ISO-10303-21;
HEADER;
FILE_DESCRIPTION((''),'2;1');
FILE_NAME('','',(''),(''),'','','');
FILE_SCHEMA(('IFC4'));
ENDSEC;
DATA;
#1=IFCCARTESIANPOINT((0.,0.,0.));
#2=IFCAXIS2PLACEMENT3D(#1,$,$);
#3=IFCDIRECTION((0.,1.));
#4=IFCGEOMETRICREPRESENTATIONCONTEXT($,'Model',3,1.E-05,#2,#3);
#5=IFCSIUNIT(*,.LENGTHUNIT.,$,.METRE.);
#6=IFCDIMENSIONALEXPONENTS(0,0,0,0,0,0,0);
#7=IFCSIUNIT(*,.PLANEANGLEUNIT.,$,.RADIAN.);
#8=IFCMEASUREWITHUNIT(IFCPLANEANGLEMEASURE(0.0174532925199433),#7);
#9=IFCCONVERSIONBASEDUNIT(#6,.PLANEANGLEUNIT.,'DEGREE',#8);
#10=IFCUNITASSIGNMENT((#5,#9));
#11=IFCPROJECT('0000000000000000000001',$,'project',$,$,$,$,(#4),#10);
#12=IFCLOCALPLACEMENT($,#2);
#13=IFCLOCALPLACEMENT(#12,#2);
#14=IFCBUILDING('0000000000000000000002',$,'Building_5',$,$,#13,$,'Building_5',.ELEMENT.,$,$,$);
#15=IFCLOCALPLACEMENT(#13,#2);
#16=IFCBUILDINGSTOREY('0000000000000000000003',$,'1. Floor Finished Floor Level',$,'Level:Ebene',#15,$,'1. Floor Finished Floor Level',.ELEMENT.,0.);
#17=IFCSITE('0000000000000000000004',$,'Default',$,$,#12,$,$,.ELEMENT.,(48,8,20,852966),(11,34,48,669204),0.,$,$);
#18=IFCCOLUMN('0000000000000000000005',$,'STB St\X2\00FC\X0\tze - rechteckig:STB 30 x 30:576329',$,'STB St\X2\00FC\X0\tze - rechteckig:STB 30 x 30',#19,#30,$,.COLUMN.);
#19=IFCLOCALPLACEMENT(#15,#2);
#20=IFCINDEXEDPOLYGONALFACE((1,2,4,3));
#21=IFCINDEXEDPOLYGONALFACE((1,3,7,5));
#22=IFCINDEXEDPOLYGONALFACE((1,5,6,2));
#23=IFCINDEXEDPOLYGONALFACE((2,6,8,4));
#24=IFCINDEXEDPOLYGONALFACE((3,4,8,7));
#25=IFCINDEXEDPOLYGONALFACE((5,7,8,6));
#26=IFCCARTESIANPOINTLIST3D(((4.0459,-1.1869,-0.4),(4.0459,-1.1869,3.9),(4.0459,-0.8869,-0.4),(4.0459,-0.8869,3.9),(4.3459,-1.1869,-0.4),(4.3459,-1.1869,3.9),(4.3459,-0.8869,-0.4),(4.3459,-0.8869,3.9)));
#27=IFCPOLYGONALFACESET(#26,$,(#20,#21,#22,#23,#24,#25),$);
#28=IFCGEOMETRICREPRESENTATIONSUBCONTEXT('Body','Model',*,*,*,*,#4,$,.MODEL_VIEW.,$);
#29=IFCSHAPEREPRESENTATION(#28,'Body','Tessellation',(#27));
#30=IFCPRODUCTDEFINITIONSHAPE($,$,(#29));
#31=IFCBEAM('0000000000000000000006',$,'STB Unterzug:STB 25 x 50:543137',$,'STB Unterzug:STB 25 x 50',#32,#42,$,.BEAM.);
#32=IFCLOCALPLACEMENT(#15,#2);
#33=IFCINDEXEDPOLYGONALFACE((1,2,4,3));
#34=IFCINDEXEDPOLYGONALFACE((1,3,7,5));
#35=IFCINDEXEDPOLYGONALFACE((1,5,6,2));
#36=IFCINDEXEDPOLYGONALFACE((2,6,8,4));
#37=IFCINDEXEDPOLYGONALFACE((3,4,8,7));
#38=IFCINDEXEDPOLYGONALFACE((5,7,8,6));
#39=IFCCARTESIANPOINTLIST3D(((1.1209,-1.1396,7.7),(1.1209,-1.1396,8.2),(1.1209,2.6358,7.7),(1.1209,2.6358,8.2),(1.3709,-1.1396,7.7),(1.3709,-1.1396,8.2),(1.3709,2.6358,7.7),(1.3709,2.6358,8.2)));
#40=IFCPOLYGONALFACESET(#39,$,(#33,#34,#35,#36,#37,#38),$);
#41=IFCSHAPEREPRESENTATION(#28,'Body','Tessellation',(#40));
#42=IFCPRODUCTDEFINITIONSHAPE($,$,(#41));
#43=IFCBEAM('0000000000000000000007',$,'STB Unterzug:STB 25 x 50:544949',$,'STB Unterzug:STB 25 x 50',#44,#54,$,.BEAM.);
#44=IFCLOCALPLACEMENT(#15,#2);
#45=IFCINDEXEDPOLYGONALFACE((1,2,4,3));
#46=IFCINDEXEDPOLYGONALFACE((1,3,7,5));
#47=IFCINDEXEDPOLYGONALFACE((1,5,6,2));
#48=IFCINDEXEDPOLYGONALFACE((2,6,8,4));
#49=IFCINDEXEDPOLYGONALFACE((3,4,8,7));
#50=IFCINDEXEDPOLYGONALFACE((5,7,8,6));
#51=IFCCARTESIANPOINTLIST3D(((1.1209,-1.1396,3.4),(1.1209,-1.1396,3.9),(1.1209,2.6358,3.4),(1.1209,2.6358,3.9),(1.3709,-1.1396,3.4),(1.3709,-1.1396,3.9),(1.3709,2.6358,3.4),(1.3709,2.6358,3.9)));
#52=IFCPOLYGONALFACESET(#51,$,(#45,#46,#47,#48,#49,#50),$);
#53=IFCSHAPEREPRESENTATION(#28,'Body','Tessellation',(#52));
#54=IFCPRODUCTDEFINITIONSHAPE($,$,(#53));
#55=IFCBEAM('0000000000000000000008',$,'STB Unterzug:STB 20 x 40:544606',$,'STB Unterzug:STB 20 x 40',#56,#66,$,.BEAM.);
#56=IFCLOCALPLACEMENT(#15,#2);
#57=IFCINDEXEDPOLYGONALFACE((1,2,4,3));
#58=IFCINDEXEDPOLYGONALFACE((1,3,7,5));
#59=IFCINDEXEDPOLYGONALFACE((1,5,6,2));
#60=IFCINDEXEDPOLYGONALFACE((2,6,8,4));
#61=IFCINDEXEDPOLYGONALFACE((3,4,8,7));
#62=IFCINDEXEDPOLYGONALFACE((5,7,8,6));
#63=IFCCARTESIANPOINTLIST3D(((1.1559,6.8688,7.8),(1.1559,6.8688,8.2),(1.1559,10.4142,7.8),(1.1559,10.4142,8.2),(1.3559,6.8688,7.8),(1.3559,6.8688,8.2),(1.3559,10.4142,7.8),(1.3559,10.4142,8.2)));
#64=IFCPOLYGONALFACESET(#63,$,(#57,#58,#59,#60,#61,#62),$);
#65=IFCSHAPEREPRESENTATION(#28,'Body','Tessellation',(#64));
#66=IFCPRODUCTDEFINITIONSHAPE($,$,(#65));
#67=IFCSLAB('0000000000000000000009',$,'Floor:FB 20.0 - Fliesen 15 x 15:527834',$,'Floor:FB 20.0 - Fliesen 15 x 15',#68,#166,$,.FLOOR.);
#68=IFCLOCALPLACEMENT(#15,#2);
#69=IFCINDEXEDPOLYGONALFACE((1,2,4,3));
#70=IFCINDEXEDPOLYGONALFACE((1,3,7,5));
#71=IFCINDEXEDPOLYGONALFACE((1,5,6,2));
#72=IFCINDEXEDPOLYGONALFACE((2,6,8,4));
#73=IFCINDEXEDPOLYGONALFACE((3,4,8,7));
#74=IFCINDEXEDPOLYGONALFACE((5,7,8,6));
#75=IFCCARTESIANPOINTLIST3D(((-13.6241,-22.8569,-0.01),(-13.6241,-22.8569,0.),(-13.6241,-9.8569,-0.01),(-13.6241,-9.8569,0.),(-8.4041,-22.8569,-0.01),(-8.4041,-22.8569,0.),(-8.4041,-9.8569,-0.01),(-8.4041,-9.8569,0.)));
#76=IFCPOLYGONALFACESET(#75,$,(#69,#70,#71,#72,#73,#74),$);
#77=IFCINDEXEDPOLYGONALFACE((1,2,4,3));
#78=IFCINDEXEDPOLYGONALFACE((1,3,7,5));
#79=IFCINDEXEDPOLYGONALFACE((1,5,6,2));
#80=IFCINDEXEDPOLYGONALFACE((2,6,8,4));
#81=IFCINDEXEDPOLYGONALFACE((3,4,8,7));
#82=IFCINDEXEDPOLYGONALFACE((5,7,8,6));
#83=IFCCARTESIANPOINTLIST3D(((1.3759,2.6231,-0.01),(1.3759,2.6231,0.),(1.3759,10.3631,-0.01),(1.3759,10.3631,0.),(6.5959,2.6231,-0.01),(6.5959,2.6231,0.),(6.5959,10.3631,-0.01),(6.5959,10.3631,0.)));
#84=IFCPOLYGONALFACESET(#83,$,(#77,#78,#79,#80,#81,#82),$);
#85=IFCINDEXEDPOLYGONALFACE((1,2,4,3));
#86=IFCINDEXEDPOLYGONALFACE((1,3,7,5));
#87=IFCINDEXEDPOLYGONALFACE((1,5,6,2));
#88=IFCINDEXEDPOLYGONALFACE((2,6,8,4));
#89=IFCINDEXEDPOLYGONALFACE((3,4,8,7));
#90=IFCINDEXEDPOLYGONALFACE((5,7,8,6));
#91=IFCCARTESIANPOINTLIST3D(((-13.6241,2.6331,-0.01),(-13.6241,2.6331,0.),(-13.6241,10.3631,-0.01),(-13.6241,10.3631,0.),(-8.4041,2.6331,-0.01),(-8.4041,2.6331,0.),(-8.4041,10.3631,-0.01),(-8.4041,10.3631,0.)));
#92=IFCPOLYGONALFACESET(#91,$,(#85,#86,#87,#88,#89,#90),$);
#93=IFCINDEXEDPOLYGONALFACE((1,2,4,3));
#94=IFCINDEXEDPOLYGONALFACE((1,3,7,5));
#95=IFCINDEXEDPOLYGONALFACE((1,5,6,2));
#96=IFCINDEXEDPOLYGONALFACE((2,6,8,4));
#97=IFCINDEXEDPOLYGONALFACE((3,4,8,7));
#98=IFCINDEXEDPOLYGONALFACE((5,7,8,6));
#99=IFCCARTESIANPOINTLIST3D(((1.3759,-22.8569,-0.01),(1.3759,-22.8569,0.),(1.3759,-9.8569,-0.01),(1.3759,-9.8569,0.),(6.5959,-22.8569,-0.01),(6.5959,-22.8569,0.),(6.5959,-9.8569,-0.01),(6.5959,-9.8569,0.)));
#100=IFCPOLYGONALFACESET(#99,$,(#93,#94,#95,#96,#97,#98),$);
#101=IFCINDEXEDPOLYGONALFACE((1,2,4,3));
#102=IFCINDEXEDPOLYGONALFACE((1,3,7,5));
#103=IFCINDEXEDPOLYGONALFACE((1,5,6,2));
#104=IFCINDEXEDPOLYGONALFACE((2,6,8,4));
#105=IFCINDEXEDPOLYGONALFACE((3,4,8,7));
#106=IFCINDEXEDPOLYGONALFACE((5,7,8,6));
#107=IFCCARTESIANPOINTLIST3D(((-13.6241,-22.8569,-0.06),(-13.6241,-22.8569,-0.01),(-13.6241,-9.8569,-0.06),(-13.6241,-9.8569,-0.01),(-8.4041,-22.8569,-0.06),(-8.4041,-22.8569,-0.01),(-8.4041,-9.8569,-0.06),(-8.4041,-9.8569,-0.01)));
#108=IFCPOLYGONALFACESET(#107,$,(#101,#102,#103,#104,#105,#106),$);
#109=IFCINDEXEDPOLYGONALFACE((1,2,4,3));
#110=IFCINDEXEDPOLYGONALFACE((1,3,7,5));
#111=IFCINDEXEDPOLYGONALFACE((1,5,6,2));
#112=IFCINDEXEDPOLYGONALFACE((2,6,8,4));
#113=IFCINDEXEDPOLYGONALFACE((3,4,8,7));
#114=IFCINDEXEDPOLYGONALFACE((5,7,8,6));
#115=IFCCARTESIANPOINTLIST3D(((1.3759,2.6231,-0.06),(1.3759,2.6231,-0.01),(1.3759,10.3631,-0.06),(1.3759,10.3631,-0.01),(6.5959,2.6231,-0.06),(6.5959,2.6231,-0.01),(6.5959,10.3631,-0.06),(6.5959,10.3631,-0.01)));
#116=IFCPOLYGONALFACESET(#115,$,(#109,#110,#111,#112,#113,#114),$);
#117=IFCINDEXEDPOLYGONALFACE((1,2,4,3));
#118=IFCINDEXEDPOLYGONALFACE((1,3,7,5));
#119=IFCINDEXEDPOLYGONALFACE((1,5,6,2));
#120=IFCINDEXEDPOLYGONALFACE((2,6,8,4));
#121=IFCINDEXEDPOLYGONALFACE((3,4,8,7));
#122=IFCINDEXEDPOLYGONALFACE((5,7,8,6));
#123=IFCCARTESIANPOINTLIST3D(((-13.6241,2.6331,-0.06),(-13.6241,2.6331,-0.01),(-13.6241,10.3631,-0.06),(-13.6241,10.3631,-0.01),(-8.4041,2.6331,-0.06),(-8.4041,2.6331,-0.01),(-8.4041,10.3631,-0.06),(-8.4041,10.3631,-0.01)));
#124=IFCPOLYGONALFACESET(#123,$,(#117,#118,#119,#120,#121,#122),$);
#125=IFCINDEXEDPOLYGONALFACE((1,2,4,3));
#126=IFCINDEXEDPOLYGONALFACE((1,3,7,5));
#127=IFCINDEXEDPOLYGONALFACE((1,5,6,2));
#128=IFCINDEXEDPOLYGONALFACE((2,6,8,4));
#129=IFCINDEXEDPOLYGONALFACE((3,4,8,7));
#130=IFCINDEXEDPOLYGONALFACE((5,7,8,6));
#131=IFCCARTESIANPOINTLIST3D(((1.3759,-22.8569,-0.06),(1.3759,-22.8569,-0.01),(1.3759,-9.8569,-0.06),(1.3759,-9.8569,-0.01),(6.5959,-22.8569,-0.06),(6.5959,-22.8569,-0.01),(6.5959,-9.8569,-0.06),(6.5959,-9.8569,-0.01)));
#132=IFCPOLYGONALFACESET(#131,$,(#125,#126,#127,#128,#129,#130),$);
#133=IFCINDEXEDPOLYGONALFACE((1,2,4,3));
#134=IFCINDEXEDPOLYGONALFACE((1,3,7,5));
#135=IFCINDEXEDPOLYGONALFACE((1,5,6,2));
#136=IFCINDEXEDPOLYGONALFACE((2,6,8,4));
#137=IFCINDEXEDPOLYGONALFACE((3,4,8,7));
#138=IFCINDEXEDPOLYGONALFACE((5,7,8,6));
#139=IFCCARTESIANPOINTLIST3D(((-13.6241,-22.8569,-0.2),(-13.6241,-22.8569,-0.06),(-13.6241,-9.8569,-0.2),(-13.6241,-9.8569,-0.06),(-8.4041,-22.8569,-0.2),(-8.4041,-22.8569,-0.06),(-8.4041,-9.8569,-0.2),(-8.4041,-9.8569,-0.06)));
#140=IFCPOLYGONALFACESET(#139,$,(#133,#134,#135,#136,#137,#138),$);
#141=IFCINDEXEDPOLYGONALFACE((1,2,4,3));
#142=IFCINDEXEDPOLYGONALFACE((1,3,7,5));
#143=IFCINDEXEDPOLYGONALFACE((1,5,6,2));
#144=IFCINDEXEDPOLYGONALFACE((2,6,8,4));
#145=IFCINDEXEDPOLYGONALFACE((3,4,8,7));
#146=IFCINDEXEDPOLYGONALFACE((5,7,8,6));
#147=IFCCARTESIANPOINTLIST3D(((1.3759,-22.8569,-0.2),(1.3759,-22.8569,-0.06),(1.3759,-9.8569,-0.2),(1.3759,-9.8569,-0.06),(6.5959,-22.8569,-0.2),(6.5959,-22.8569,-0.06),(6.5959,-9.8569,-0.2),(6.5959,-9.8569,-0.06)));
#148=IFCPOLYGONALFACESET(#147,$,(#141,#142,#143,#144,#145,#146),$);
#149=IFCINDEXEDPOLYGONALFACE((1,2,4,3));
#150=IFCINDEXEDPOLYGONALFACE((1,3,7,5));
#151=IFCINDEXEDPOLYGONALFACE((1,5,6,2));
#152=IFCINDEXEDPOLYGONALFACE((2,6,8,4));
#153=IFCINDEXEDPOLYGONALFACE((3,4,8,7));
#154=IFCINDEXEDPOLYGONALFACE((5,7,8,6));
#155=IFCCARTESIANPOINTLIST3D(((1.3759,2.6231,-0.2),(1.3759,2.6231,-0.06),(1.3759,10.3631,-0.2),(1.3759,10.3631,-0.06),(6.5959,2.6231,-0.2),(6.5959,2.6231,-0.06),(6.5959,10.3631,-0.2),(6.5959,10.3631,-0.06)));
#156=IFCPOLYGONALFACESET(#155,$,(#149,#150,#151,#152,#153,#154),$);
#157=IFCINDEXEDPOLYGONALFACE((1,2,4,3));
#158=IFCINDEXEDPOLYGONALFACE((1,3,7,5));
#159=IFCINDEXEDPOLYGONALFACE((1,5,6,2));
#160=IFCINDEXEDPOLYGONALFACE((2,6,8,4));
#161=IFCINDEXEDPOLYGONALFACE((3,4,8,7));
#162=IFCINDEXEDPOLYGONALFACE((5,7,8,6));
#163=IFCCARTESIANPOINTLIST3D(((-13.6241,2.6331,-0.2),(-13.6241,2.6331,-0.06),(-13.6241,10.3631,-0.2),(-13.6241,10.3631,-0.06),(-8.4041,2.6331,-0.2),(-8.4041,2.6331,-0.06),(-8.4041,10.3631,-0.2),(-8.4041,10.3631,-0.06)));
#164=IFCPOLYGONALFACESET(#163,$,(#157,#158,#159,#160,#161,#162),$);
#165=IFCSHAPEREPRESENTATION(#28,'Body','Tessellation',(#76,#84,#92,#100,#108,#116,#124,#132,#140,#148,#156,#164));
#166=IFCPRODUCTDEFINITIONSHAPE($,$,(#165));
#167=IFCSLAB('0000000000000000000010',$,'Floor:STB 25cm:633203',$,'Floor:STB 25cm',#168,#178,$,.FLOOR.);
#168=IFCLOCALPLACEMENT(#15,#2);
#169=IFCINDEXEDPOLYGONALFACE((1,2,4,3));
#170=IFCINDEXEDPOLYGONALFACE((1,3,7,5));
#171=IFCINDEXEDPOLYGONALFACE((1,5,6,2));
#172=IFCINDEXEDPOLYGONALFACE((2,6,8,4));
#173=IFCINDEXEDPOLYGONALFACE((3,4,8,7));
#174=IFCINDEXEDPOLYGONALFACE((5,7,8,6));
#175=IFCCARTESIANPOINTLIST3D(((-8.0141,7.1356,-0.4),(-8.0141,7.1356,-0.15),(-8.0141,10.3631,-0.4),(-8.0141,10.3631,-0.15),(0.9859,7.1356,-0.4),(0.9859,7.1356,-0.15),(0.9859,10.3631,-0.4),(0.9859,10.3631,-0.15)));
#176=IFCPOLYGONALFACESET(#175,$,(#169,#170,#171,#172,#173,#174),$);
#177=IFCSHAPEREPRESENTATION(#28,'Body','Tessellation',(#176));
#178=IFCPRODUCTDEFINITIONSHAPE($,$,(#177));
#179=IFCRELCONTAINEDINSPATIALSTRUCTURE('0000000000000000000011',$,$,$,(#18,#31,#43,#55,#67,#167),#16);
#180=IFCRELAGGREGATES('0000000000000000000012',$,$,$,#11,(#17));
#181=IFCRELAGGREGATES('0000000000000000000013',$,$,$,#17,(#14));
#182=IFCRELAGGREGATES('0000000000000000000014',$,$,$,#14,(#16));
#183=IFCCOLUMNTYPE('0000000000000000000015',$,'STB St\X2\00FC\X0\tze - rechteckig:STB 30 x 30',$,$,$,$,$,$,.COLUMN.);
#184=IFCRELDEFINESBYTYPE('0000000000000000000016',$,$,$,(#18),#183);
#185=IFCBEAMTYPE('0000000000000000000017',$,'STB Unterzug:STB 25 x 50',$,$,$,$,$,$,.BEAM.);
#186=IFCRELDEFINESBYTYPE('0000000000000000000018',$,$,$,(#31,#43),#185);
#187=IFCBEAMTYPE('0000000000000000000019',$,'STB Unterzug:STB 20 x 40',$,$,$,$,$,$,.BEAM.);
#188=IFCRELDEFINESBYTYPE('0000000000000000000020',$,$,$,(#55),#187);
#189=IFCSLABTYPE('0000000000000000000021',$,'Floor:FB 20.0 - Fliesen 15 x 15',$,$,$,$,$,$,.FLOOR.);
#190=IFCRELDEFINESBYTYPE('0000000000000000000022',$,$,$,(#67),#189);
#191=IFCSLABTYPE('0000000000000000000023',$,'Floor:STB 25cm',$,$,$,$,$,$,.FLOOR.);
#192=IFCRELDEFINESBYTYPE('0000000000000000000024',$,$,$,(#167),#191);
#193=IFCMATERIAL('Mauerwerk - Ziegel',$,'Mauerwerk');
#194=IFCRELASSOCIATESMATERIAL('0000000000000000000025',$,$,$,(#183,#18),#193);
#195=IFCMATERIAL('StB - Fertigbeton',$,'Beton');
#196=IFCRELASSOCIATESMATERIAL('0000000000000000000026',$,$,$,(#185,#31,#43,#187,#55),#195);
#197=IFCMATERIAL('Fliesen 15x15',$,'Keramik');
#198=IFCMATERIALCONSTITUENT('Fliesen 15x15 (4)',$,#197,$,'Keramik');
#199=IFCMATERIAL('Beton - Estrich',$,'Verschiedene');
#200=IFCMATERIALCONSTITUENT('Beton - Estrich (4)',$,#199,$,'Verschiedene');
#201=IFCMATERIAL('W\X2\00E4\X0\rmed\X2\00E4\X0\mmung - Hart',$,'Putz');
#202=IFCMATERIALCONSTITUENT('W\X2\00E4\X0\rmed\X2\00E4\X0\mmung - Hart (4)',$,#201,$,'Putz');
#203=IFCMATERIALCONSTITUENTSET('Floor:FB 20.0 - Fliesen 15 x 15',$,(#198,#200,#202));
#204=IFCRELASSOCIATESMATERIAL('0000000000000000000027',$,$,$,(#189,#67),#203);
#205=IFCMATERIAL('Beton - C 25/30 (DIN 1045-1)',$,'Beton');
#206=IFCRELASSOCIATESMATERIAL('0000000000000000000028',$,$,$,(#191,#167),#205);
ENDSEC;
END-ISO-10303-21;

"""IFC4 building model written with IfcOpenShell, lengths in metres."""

from ifc_helpers import new_model, entity, si_unit, converted_unit, direction, frame, origin, place, context, subcontext, project, spatial, indexed_curve, outline, extrude, source, transform, mapped, material, constituent, constituent_set, type_object, type_shapes, element, save


model = new_model("IFC4")

# Units and contexts
model_context = context("Model", 3, precision=1e-05, world=origin(), true_north=direction((0.0, 1.0)))
body_context = subcontext(model_context, "Body", "Model", "MODEL_VIEW")
ifc_project = project(units=[si_unit("LENGTHUNIT", "METRE"), converted_unit("PLANEANGLEUNIT", "DEGREE", entity("IfcPlaneAngleMeasure", 0.0174532925199433), si_unit("PLANEANGLEUNIT", "RADIAN"), dimensions=[0, 0, 0, 0, 0, 0, 0])], contexts=[model_context])

# Site, building, storey
site_placement = place(None, origin())
site = spatial("IfcSite", under=ifc_project, at=site_placement, Name="Default", CompositionType="ELEMENT", RefLatitude=(48, 8, 20, 852966), RefLongitude=(11, 34, 48, 669204), RefElevation=0.0)
building_placement = place(site_placement, origin())
building = spatial("IfcBuilding", under=site, at=building_placement, Name="Building_5", LongName="Building_5", CompositionType="ELEMENT")
storey_placement = place(building_placement, origin())
storey = spatial("IfcBuildingStorey", under=building, at=storey_placement, Name="1. Floor Finished Floor Level", ObjectType="Level:Ebene", LongName="1. Floor Finished Floor Level", CompositionType="ELEMENT", Elevation=0.0)

# Column
ifc_material_1 = material(Name="Mauerwerk - Ziegel", Category="Mauerwerk")
column_type = type_object("IfcColumnType", Name="STB Stütze - rechteckig:STB 30 x 30", PredefinedType="COLUMN", material=ifc_material_1)
shared_shape_1 = source(origin(), body_context, "Body", "SweptSolid", [
    extrude(outline(indexed_curve([(-0.15, -0.15), (0.15, -0.15), (0.15, 0.15), (-0.15, 0.15), (-0.15, -0.15)], self_intersect=False)), frame((0.0, 0.0, -0.4), z_axis=(0.0, 0.0, 1.0), x_axis=(-1.0, 0.0, 0.0)), (0.0, 0.0, 1.0), 4.3),
])
type_shapes(column_type, [shared_shape_1])
column_placement = place(storey_placement, frame((4.1959, -1.0369, 0.0)))
element("IfcColumn", 1, at=column_placement, inside=storey, type_object=column_type, material=ifc_material_1, Name="STB Stütze - rechteckig:STB 30 x 30:576329", ObjectType="STB Stütze - rechteckig:STB 30 x 30", PredefinedType="COLUMN", context=body_context, shape_type="MappedRepresentation", body=[
    mapped(shared_shape_1, transform((0.0, 0.0, 0.0), scale=1.0)),
])

# Beams
ifc_material_2 = material(Name="StB - Fertigbeton", Category="Beton")
beam_type_1 = type_object("IfcBeamType", Name="STB Unterzug:STB 25 x 50", PredefinedType="BEAM", material=ifc_material_2)
shared_shape_2 = source(origin(), body_context, "Body", "SweptSolid", [
    extrude(outline(indexed_curve([(-1.8877, -0.125), (1.8877, -0.125), (1.8877, 0.125), (-1.8877, 0.125), (-1.8877, -0.125)], self_intersect=False)), frame((0.0, 0.0, -0.25), z_axis=(0.0, 0.0, 1.0), x_axis=(-1.0, 0.0, 0.0)), (0.0, 0.0, 1.0), 0.5),
])
type_shapes(beam_type_1, [shared_shape_2])
for number, where, z_axis, x_axis, name in (
    (2, (1.2459, 0.7481, 7.95), (0.0, 0.0, 1.0), (0.0, 1.0, 0.0), "STB Unterzug:STB 25 x 50:543137"),
    (3, (1.2459, 0.7481, 3.65), (0.0, 0.0, 1.0), (0.0, 1.0, 0.0), "STB Unterzug:STB 25 x 50:544949"),
):
    element("IfcBeam", number, at=place(storey_placement, frame(where, z_axis=z_axis, x_axis=x_axis)), inside=storey, type_object=beam_type_1, material=ifc_material_2, Name=name, ObjectType="STB Unterzug:STB 25 x 50", PredefinedType="BEAM", context=body_context, shape_type="MappedRepresentation", body=[
        mapped(shared_shape_2, transform((0.0, 0.0, 0.0), scale=1.0)),
    ])
beam_type_2 = type_object("IfcBeamType", Name="STB Unterzug:STB 20 x 40", PredefinedType="BEAM", material=ifc_material_2)
shared_shape_3 = source(origin(), body_context, "Body", "SweptSolid", [
    extrude(outline(indexed_curve([(-1.7727, -0.1), (1.7727, -0.1), (1.7727, 0.1), (-1.7727, 0.1), (-1.7727, -0.1)], self_intersect=False)), frame((0.0, 0.0, -0.2), z_axis=(0.0, 0.0, 1.0), x_axis=(-1.0, 0.0, 0.0)), (0.0, 0.0, 1.0), 0.4),
])
type_shapes(beam_type_2, [shared_shape_3])
beam_placement = place(storey_placement, frame((1.2559, 8.6415, 8.0), z_axis=(0.0, 0.0, 1.0), x_axis=(0.0, 1.0, 0.0)))
element("IfcBeam", 4, at=beam_placement, inside=storey, type_object=beam_type_2, material=ifc_material_2, Name="STB Unterzug:STB 20 x 40:544606", ObjectType="STB Unterzug:STB 20 x 40", PredefinedType="BEAM", context=body_context, shape_type="MappedRepresentation", body=[
    mapped(shared_shape_3, transform((0.0, 0.0, 0.0), scale=1.0)),
])

# Slabs
ifc_material_3 = material(Name="Fliesen 15x15", Category="Keramik")
ifc_constituent_1 = constituent(ifc_material_3, Name="Fliesen 15x15 (4)", Category="Keramik")
ifc_material_4 = material(Name="Beton - Estrich", Category="Verschiedene")
ifc_constituent_2 = constituent(ifc_material_4, Name="Beton - Estrich (4)", Category="Verschiedene")
ifc_material_5 = material(Name="Wärmedämmung - Hart", Category="Putz")
ifc_constituent_3 = constituent(ifc_material_5, Name="Wärmedämmung - Hart (4)", Category="Putz")
ifc_constituent_set_1 = constituent_set(constituents=[ifc_constituent_1, ifc_constituent_2, ifc_constituent_3], Name="Floor:FB 20.0 - Fliesen 15 x 15")
slab_type_1 = type_object("IfcSlabType", Name="Floor:FB 20.0 - Fliesen 15 x 15", PredefinedType="FLOOR", material=ifc_constituent_set_1)
slab_1_placement = place(storey_placement, origin())
element("IfcSlab", 5, at=slab_1_placement, inside=storey, type_object=slab_type_1, material=ifc_constituent_set_1, Name="Floor:FB 20.0 - Fliesen 15 x 15:527834", ObjectType="Floor:FB 20.0 - Fliesen 15 x 15", PredefinedType="FLOOR", context=body_context, shape_type="SweptSolid", body=[
    extrude(outline(indexed_curve([(-2.61, -6.5), (2.61, -6.5), (2.61, 6.5), (-2.61, 6.5), (-2.61, -6.5)], self_intersect=False)), frame((-11.0141, -16.3569, -0.01), z_axis=(0.0, 0.0, 1.0), x_axis=(-1.0, 0.0, 0.0)), (0.0, 0.0, 1.0), 0.01),
    extrude(outline(indexed_curve([(-2.61, -3.87), (2.61, -3.87), (2.61, 3.87), (-2.61, 3.87), (-2.61, -3.87)], self_intersect=False)), frame((3.9859, 6.4931, -0.01), z_axis=(0.0, 0.0, 1.0), x_axis=(-1.0, 0.0, 0.0)), (0.0, 0.0, 1.0), 0.01),
    extrude(outline(indexed_curve([(-2.61, -3.865), (2.61, -3.865), (2.61, 3.865), (-2.61, 3.865), (-2.61, -3.865)], self_intersect=False)), frame((-11.0141, 6.4981, -0.01), z_axis=(0.0, 0.0, 1.0), x_axis=(-1.0, 0.0, 0.0)), (0.0, 0.0, 1.0), 0.01),
    extrude(outline(indexed_curve([(-2.61, -6.5), (2.61, -6.5), (2.61, 6.5), (-2.61, 6.5), (-2.61, -6.5)], self_intersect=False)), frame((3.9859, -16.3569, -0.01), z_axis=(0.0, 0.0, 1.0), x_axis=(-1.0, 0.0, 0.0)), (0.0, 0.0, 1.0), 0.01),
    extrude(outline(indexed_curve([(-2.61, -6.5), (2.61, -6.5), (2.61, 6.5), (-2.61, 6.5), (-2.61, -6.5)], self_intersect=False)), frame((-11.0141, -16.3569, -0.06), z_axis=(0.0, 0.0, 1.0), x_axis=(-1.0, 0.0, 0.0)), (0.0, 0.0, 1.0), 0.05),
    extrude(outline(indexed_curve([(-2.61, -3.87), (2.61, -3.87), (2.61, 3.87), (-2.61, 3.87), (-2.61, -3.87)], self_intersect=False)), frame((3.9859, 6.4931, -0.06), z_axis=(0.0, 0.0, 1.0), x_axis=(-1.0, 0.0, 0.0)), (0.0, 0.0, 1.0), 0.05),
    extrude(outline(indexed_curve([(-2.61, -3.865), (2.61, -3.865), (2.61, 3.865), (-2.61, 3.865), (-2.61, -3.865)], self_intersect=False)), frame((-11.0141, 6.4981, -0.06), z_axis=(0.0, 0.0, 1.0), x_axis=(-1.0, 0.0, 0.0)), (0.0, 0.0, 1.0), 0.05),
    extrude(outline(indexed_curve([(-2.61, -6.5), (2.61, -6.5), (2.61, 6.5), (-2.61, 6.5), (-2.61, -6.5)], self_intersect=False)), frame((3.9859, -16.3569, -0.06), z_axis=(0.0, 0.0, 1.0), x_axis=(-1.0, 0.0, 0.0)), (0.0, 0.0, 1.0), 0.05),
    extrude(outline(indexed_curve([(-2.61, -6.5), (2.61, -6.5), (2.61, 6.5), (-2.61, 6.5), (-2.61, -6.5)], self_intersect=False)), frame((-11.0141, -16.3569, -0.2), z_axis=(0.0, 0.0, 1.0), x_axis=(-1.0, 0.0, 0.0)), (0.0, 0.0, 1.0), 0.14),
    extrude(outline(indexed_curve([(-2.61, -6.5), (2.61, -6.5), (2.61, 6.5), (-2.61, 6.5), (-2.61, -6.5)], self_intersect=False)), frame((3.9859, -16.3569, -0.2), z_axis=(0.0, 0.0, 1.0), x_axis=(-1.0, 0.0, 0.0)), (0.0, 0.0, 1.0), 0.14),
    extrude(outline(indexed_curve([(-2.61, -3.87), (2.61, -3.87), (2.61, 3.87), (-2.61, 3.87), (-2.61, -3.87)], self_intersect=False)), frame((3.9859, 6.4931, -0.2), z_axis=(0.0, 0.0, 1.0), x_axis=(-1.0, 0.0, 0.0)), (0.0, 0.0, 1.0), 0.14),
    extrude(outline(indexed_curve([(-2.61, -3.865), (2.61, -3.865), (2.61, 3.865), (-2.61, 3.865), (-2.61, -3.865)], self_intersect=False)), frame((-11.0141, 6.4981, -0.2), z_axis=(0.0, 0.0, 1.0), x_axis=(-1.0, 0.0, 0.0)), (0.0, 0.0, 1.0), 0.14),
])
ifc_material_6 = material(Name="Beton - C 25/30 (DIN 1045-1)", Category="Beton")
slab_type_2 = type_object("IfcSlabType", Name="Floor:STB 25cm", PredefinedType="FLOOR", material=ifc_material_6)
slab_2_placement = place(storey_placement, origin())
element("IfcSlab", 6, at=slab_2_placement, inside=storey, type_object=slab_type_2, material=ifc_material_6, Name="Floor:STB 25cm:633203", ObjectType="Floor:STB 25cm", PredefinedType="FLOOR", context=body_context, shape_type="SweptSolid", body=[
    extrude(outline(indexed_curve([(-1.6138, -4.5), (1.6138, -4.5), (1.6138, 4.5), (-1.6138, 4.5), (-1.6138, -4.5)], self_intersect=False)), frame((-3.5141, 8.7494, -0.15), z_axis=(0.0, 0.0, -1.0), x_axis=(0.0, 1.0, 0.0)), (0.0, 0.0, 1.0), 0.25),
])

save(model, "model.ifc")
